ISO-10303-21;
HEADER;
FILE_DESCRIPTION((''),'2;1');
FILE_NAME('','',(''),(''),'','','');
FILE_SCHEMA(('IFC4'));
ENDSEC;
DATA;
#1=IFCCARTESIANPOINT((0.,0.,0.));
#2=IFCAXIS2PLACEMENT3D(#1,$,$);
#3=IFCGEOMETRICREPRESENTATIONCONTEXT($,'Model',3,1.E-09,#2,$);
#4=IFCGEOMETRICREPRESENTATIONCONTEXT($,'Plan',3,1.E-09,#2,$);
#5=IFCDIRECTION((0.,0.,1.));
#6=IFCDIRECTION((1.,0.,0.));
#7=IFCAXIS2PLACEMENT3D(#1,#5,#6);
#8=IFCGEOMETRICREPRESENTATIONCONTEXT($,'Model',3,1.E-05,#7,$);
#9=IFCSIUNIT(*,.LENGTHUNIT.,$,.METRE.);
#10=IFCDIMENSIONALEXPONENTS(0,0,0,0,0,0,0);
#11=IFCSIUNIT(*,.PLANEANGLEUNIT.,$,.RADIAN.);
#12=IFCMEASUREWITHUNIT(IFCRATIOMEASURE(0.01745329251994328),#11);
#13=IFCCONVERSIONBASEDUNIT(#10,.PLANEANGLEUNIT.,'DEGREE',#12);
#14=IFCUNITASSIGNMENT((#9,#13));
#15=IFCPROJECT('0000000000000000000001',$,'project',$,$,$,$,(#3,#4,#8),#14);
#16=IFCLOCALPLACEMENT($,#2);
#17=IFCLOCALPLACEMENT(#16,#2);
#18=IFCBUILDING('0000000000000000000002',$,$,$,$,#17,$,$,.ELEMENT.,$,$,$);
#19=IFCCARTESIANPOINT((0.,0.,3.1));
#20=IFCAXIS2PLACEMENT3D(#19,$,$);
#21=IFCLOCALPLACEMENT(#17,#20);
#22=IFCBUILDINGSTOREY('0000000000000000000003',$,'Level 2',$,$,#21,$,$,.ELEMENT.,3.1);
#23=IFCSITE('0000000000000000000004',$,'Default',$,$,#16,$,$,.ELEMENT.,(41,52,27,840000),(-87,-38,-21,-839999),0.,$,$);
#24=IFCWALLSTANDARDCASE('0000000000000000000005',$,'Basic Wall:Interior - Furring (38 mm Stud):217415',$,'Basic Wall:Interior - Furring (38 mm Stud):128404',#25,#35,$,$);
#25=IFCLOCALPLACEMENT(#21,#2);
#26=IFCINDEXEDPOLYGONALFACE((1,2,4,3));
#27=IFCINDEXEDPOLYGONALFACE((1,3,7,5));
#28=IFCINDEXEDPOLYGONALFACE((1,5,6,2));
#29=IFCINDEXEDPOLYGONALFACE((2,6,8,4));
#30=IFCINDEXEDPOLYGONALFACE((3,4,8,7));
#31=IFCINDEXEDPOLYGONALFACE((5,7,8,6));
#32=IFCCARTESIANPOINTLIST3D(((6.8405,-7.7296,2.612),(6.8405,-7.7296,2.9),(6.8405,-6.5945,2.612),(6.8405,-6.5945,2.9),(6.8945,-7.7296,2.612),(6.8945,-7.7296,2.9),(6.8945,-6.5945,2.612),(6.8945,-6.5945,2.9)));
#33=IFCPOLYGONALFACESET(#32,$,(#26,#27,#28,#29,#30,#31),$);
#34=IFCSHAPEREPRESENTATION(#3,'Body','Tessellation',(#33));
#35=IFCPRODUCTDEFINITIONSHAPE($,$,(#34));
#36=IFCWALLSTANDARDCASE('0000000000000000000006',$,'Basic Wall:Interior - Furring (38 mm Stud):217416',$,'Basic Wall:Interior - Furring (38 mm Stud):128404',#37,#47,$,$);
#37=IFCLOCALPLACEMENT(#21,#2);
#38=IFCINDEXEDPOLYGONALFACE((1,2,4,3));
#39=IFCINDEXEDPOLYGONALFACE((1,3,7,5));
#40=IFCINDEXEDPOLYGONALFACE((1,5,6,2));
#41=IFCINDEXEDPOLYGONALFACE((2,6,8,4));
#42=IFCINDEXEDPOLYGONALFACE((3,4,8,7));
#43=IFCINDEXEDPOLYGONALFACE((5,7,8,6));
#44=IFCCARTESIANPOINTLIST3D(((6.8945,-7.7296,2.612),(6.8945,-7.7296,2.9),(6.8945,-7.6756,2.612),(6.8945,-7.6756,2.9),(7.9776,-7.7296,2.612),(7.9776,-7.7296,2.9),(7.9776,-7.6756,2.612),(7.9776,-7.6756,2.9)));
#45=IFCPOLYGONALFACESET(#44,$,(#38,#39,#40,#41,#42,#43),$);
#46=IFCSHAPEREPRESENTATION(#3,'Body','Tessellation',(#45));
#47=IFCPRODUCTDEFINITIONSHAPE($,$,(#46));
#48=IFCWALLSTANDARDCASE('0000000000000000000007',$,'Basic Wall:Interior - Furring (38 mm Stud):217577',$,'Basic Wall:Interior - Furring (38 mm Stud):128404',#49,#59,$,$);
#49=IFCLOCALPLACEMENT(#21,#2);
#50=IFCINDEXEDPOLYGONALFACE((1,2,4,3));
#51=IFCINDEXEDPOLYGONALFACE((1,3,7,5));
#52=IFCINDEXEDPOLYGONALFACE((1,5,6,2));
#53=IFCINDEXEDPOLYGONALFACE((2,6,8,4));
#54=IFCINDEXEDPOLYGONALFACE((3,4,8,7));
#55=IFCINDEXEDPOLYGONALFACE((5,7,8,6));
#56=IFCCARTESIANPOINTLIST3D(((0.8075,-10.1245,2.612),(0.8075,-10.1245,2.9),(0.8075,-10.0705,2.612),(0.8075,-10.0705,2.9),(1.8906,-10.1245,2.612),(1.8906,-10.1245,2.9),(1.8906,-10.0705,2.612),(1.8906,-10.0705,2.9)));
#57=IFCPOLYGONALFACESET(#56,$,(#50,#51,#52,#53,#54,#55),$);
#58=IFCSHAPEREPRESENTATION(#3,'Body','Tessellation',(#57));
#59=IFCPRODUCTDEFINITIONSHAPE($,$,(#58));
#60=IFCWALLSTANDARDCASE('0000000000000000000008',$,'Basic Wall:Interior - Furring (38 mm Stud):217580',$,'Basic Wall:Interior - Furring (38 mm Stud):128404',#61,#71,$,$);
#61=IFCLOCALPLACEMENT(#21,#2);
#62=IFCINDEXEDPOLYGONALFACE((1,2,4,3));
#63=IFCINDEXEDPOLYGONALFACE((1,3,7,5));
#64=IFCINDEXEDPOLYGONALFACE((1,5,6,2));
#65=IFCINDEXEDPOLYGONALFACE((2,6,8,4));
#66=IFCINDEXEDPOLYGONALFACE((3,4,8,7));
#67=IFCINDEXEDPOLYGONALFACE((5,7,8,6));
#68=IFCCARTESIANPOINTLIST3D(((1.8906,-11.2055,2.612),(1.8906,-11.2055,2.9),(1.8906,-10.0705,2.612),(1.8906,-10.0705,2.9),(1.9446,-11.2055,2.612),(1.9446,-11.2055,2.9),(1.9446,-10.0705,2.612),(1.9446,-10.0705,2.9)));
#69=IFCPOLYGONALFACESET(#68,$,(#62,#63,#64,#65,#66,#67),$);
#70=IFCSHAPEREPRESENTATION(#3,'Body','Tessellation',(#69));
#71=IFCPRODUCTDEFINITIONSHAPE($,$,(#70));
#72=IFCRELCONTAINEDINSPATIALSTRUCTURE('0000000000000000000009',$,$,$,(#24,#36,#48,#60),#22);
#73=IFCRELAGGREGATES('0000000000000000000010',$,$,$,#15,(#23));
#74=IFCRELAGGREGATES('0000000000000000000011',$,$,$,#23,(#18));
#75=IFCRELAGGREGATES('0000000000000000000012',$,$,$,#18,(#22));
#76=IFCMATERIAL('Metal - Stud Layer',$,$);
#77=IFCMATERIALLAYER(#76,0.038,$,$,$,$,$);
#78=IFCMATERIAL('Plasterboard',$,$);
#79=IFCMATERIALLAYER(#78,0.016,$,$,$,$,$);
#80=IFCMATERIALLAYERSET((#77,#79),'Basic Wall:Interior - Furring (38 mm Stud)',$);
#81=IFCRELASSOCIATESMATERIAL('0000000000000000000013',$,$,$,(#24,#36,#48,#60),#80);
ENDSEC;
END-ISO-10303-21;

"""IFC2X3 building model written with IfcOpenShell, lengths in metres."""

from ifc_helpers import new_model, entity, si_unit, converted_unit, frame, frame_2d, origin, origin_with_axes, place, context, project, spatial, rectangle, extrude, material, layer, layer_set, layer_usage, element, save


model = new_model("IFC2X3")

# Units and contexts
model_context_1 = context("Model", 3, precision=1e-09, world=origin())
plan_context = context("Plan", 3, precision=1e-09, world=origin())
model_context_2 = context("Model", 3, precision=1e-05, world=origin_with_axes())
ifc_project = project(units=[si_unit("LENGTHUNIT", "METRE"), converted_unit("PLANEANGLEUNIT", "DEGREE", entity("IfcRatioMeasure", 0.01745329251994328), si_unit("PLANEANGLEUNIT", "RADIAN"), dimensions=[0, 0, 0, 0, 0, 0, 0])], contexts=[model_context_1, plan_context, model_context_2])

# Site, building, storey
site_placement = place(None, origin())
site = spatial("IfcSite", under=ifc_project, at=site_placement, Name="Default", CompositionType="ELEMENT", RefLatitude=(41, 52, 27, 840000), RefLongitude=(-87, -38, -21, -839999), RefElevation=0.0)
building_placement = place(site_placement, origin())
building = spatial("IfcBuilding", under=site, at=building_placement, CompositionType="ELEMENT")
storey_placement = place(building_placement, frame((0.0, 0.0, 3.1)))
storey = spatial("IfcBuildingStorey", under=building, at=storey_placement, Name="Level 2", CompositionType="ELEMENT", Elevation=3.1)

# Shared definitions
ifc_material_1 = material(Name="Plasterboard")
ifc_material_2 = material(Name="Metal - Stud Layer")

# Walls
ifc_layer_1 = layer(ifc_material_2, 0.038)
ifc_layer_2 = layer(ifc_material_1, 0.016)
ifc_layer_set_1 = layer_set([ifc_layer_1, ifc_layer_2], Name="Basic Wall:Interior - Furring (38 mm Stud)")
ifc_layer_usage_1 = layer_usage(ifc_layer_set_1, "AXIS2", "NEGATIVE", 0.027)
wall_1_placement = place(storey_placement, frame((6.8675, -7.7296, 2.612), z_axis=(0.0, 0.0, 1.0), x_axis=(0.0, 1.0, 0.0)))
element("IfcWallStandardCase", 1, at=wall_1_placement, inside=storey, material=ifc_layer_usage_1, Name="Basic Wall:Interior - Furring (38 mm Stud):217415", ObjectType="Basic Wall:Interior - Furring (38 mm Stud):128404", context=model_context_1, shape_type="SweptSolid", body=[
    extrude(rectangle(XDim=1.1351, YDim=0.054, at=frame_2d((0.5675, 0.0), x_axis=(-1.0, 0.0))), origin(), (0.0, 0.0, 1.0), 0.288),
])
ifc_layer_usage_2 = layer_usage(ifc_layer_set_1, "AXIS2", "NEGATIVE", 0.027)
wall_2_placement = place(storey_placement, frame((7.9776, -7.7026, 2.612), z_axis=(0.0, 0.0, 1.0), x_axis=(-1.0, 0.0, 0.0)))
element("IfcWallStandardCase", 2, at=wall_2_placement, inside=storey, material=ifc_layer_usage_2, Name="Basic Wall:Interior - Furring (38 mm Stud):217416", ObjectType="Basic Wall:Interior - Furring (38 mm Stud):128404", context=model_context_1, shape_type="SweptSolid", body=[
    extrude(rectangle(XDim=1.0831, YDim=0.054, at=frame_2d((0.5416, 0.0), x_axis=(-1.0, 0.0))), origin(), (0.0, 0.0, 1.0), 0.288),
])
ifc_layer_usage_3 = layer_usage(ifc_layer_set_1, "AXIS2", "NEGATIVE", 0.027)
wall_3_placement = place(storey_placement, frame((0.8075, -10.0975, 2.612)))
element("IfcWallStandardCase", 3, at=wall_3_placement, inside=storey, material=ifc_layer_usage_3, Name="Basic Wall:Interior - Furring (38 mm Stud):217577", ObjectType="Basic Wall:Interior - Furring (38 mm Stud):128404", context=model_context_1, shape_type="SweptSolid", body=[
    extrude(rectangle(XDim=1.0831, YDim=0.054, at=frame_2d((0.5415, 0.0), x_axis=(-1.0, 0.0))), origin(), (0.0, 0.0, 1.0), 0.288),
])
ifc_layer_usage_4 = layer_usage(ifc_layer_set_1, "AXIS2", "NEGATIVE", 0.027)
wall_4_placement = place(storey_placement, frame((1.9176, -10.0705, 2.612), z_axis=(0.0, 0.0, 1.0), x_axis=(0.0, -1.0, 0.0)))
element("IfcWallStandardCase", 4, at=wall_4_placement, inside=storey, material=ifc_layer_usage_4, Name="Basic Wall:Interior - Furring (38 mm Stud):217580", ObjectType="Basic Wall:Interior - Furring (38 mm Stud):128404", context=model_context_1, shape_type="SweptSolid", body=[
    extrude(rectangle(XDim=1.1351, YDim=0.054, at=frame_2d((0.5675, 0.0), x_axis=(-1.0, 0.0))), origin(), (0.0, 0.0, 1.0), 0.288),
])

save(model, "model.ifc")
